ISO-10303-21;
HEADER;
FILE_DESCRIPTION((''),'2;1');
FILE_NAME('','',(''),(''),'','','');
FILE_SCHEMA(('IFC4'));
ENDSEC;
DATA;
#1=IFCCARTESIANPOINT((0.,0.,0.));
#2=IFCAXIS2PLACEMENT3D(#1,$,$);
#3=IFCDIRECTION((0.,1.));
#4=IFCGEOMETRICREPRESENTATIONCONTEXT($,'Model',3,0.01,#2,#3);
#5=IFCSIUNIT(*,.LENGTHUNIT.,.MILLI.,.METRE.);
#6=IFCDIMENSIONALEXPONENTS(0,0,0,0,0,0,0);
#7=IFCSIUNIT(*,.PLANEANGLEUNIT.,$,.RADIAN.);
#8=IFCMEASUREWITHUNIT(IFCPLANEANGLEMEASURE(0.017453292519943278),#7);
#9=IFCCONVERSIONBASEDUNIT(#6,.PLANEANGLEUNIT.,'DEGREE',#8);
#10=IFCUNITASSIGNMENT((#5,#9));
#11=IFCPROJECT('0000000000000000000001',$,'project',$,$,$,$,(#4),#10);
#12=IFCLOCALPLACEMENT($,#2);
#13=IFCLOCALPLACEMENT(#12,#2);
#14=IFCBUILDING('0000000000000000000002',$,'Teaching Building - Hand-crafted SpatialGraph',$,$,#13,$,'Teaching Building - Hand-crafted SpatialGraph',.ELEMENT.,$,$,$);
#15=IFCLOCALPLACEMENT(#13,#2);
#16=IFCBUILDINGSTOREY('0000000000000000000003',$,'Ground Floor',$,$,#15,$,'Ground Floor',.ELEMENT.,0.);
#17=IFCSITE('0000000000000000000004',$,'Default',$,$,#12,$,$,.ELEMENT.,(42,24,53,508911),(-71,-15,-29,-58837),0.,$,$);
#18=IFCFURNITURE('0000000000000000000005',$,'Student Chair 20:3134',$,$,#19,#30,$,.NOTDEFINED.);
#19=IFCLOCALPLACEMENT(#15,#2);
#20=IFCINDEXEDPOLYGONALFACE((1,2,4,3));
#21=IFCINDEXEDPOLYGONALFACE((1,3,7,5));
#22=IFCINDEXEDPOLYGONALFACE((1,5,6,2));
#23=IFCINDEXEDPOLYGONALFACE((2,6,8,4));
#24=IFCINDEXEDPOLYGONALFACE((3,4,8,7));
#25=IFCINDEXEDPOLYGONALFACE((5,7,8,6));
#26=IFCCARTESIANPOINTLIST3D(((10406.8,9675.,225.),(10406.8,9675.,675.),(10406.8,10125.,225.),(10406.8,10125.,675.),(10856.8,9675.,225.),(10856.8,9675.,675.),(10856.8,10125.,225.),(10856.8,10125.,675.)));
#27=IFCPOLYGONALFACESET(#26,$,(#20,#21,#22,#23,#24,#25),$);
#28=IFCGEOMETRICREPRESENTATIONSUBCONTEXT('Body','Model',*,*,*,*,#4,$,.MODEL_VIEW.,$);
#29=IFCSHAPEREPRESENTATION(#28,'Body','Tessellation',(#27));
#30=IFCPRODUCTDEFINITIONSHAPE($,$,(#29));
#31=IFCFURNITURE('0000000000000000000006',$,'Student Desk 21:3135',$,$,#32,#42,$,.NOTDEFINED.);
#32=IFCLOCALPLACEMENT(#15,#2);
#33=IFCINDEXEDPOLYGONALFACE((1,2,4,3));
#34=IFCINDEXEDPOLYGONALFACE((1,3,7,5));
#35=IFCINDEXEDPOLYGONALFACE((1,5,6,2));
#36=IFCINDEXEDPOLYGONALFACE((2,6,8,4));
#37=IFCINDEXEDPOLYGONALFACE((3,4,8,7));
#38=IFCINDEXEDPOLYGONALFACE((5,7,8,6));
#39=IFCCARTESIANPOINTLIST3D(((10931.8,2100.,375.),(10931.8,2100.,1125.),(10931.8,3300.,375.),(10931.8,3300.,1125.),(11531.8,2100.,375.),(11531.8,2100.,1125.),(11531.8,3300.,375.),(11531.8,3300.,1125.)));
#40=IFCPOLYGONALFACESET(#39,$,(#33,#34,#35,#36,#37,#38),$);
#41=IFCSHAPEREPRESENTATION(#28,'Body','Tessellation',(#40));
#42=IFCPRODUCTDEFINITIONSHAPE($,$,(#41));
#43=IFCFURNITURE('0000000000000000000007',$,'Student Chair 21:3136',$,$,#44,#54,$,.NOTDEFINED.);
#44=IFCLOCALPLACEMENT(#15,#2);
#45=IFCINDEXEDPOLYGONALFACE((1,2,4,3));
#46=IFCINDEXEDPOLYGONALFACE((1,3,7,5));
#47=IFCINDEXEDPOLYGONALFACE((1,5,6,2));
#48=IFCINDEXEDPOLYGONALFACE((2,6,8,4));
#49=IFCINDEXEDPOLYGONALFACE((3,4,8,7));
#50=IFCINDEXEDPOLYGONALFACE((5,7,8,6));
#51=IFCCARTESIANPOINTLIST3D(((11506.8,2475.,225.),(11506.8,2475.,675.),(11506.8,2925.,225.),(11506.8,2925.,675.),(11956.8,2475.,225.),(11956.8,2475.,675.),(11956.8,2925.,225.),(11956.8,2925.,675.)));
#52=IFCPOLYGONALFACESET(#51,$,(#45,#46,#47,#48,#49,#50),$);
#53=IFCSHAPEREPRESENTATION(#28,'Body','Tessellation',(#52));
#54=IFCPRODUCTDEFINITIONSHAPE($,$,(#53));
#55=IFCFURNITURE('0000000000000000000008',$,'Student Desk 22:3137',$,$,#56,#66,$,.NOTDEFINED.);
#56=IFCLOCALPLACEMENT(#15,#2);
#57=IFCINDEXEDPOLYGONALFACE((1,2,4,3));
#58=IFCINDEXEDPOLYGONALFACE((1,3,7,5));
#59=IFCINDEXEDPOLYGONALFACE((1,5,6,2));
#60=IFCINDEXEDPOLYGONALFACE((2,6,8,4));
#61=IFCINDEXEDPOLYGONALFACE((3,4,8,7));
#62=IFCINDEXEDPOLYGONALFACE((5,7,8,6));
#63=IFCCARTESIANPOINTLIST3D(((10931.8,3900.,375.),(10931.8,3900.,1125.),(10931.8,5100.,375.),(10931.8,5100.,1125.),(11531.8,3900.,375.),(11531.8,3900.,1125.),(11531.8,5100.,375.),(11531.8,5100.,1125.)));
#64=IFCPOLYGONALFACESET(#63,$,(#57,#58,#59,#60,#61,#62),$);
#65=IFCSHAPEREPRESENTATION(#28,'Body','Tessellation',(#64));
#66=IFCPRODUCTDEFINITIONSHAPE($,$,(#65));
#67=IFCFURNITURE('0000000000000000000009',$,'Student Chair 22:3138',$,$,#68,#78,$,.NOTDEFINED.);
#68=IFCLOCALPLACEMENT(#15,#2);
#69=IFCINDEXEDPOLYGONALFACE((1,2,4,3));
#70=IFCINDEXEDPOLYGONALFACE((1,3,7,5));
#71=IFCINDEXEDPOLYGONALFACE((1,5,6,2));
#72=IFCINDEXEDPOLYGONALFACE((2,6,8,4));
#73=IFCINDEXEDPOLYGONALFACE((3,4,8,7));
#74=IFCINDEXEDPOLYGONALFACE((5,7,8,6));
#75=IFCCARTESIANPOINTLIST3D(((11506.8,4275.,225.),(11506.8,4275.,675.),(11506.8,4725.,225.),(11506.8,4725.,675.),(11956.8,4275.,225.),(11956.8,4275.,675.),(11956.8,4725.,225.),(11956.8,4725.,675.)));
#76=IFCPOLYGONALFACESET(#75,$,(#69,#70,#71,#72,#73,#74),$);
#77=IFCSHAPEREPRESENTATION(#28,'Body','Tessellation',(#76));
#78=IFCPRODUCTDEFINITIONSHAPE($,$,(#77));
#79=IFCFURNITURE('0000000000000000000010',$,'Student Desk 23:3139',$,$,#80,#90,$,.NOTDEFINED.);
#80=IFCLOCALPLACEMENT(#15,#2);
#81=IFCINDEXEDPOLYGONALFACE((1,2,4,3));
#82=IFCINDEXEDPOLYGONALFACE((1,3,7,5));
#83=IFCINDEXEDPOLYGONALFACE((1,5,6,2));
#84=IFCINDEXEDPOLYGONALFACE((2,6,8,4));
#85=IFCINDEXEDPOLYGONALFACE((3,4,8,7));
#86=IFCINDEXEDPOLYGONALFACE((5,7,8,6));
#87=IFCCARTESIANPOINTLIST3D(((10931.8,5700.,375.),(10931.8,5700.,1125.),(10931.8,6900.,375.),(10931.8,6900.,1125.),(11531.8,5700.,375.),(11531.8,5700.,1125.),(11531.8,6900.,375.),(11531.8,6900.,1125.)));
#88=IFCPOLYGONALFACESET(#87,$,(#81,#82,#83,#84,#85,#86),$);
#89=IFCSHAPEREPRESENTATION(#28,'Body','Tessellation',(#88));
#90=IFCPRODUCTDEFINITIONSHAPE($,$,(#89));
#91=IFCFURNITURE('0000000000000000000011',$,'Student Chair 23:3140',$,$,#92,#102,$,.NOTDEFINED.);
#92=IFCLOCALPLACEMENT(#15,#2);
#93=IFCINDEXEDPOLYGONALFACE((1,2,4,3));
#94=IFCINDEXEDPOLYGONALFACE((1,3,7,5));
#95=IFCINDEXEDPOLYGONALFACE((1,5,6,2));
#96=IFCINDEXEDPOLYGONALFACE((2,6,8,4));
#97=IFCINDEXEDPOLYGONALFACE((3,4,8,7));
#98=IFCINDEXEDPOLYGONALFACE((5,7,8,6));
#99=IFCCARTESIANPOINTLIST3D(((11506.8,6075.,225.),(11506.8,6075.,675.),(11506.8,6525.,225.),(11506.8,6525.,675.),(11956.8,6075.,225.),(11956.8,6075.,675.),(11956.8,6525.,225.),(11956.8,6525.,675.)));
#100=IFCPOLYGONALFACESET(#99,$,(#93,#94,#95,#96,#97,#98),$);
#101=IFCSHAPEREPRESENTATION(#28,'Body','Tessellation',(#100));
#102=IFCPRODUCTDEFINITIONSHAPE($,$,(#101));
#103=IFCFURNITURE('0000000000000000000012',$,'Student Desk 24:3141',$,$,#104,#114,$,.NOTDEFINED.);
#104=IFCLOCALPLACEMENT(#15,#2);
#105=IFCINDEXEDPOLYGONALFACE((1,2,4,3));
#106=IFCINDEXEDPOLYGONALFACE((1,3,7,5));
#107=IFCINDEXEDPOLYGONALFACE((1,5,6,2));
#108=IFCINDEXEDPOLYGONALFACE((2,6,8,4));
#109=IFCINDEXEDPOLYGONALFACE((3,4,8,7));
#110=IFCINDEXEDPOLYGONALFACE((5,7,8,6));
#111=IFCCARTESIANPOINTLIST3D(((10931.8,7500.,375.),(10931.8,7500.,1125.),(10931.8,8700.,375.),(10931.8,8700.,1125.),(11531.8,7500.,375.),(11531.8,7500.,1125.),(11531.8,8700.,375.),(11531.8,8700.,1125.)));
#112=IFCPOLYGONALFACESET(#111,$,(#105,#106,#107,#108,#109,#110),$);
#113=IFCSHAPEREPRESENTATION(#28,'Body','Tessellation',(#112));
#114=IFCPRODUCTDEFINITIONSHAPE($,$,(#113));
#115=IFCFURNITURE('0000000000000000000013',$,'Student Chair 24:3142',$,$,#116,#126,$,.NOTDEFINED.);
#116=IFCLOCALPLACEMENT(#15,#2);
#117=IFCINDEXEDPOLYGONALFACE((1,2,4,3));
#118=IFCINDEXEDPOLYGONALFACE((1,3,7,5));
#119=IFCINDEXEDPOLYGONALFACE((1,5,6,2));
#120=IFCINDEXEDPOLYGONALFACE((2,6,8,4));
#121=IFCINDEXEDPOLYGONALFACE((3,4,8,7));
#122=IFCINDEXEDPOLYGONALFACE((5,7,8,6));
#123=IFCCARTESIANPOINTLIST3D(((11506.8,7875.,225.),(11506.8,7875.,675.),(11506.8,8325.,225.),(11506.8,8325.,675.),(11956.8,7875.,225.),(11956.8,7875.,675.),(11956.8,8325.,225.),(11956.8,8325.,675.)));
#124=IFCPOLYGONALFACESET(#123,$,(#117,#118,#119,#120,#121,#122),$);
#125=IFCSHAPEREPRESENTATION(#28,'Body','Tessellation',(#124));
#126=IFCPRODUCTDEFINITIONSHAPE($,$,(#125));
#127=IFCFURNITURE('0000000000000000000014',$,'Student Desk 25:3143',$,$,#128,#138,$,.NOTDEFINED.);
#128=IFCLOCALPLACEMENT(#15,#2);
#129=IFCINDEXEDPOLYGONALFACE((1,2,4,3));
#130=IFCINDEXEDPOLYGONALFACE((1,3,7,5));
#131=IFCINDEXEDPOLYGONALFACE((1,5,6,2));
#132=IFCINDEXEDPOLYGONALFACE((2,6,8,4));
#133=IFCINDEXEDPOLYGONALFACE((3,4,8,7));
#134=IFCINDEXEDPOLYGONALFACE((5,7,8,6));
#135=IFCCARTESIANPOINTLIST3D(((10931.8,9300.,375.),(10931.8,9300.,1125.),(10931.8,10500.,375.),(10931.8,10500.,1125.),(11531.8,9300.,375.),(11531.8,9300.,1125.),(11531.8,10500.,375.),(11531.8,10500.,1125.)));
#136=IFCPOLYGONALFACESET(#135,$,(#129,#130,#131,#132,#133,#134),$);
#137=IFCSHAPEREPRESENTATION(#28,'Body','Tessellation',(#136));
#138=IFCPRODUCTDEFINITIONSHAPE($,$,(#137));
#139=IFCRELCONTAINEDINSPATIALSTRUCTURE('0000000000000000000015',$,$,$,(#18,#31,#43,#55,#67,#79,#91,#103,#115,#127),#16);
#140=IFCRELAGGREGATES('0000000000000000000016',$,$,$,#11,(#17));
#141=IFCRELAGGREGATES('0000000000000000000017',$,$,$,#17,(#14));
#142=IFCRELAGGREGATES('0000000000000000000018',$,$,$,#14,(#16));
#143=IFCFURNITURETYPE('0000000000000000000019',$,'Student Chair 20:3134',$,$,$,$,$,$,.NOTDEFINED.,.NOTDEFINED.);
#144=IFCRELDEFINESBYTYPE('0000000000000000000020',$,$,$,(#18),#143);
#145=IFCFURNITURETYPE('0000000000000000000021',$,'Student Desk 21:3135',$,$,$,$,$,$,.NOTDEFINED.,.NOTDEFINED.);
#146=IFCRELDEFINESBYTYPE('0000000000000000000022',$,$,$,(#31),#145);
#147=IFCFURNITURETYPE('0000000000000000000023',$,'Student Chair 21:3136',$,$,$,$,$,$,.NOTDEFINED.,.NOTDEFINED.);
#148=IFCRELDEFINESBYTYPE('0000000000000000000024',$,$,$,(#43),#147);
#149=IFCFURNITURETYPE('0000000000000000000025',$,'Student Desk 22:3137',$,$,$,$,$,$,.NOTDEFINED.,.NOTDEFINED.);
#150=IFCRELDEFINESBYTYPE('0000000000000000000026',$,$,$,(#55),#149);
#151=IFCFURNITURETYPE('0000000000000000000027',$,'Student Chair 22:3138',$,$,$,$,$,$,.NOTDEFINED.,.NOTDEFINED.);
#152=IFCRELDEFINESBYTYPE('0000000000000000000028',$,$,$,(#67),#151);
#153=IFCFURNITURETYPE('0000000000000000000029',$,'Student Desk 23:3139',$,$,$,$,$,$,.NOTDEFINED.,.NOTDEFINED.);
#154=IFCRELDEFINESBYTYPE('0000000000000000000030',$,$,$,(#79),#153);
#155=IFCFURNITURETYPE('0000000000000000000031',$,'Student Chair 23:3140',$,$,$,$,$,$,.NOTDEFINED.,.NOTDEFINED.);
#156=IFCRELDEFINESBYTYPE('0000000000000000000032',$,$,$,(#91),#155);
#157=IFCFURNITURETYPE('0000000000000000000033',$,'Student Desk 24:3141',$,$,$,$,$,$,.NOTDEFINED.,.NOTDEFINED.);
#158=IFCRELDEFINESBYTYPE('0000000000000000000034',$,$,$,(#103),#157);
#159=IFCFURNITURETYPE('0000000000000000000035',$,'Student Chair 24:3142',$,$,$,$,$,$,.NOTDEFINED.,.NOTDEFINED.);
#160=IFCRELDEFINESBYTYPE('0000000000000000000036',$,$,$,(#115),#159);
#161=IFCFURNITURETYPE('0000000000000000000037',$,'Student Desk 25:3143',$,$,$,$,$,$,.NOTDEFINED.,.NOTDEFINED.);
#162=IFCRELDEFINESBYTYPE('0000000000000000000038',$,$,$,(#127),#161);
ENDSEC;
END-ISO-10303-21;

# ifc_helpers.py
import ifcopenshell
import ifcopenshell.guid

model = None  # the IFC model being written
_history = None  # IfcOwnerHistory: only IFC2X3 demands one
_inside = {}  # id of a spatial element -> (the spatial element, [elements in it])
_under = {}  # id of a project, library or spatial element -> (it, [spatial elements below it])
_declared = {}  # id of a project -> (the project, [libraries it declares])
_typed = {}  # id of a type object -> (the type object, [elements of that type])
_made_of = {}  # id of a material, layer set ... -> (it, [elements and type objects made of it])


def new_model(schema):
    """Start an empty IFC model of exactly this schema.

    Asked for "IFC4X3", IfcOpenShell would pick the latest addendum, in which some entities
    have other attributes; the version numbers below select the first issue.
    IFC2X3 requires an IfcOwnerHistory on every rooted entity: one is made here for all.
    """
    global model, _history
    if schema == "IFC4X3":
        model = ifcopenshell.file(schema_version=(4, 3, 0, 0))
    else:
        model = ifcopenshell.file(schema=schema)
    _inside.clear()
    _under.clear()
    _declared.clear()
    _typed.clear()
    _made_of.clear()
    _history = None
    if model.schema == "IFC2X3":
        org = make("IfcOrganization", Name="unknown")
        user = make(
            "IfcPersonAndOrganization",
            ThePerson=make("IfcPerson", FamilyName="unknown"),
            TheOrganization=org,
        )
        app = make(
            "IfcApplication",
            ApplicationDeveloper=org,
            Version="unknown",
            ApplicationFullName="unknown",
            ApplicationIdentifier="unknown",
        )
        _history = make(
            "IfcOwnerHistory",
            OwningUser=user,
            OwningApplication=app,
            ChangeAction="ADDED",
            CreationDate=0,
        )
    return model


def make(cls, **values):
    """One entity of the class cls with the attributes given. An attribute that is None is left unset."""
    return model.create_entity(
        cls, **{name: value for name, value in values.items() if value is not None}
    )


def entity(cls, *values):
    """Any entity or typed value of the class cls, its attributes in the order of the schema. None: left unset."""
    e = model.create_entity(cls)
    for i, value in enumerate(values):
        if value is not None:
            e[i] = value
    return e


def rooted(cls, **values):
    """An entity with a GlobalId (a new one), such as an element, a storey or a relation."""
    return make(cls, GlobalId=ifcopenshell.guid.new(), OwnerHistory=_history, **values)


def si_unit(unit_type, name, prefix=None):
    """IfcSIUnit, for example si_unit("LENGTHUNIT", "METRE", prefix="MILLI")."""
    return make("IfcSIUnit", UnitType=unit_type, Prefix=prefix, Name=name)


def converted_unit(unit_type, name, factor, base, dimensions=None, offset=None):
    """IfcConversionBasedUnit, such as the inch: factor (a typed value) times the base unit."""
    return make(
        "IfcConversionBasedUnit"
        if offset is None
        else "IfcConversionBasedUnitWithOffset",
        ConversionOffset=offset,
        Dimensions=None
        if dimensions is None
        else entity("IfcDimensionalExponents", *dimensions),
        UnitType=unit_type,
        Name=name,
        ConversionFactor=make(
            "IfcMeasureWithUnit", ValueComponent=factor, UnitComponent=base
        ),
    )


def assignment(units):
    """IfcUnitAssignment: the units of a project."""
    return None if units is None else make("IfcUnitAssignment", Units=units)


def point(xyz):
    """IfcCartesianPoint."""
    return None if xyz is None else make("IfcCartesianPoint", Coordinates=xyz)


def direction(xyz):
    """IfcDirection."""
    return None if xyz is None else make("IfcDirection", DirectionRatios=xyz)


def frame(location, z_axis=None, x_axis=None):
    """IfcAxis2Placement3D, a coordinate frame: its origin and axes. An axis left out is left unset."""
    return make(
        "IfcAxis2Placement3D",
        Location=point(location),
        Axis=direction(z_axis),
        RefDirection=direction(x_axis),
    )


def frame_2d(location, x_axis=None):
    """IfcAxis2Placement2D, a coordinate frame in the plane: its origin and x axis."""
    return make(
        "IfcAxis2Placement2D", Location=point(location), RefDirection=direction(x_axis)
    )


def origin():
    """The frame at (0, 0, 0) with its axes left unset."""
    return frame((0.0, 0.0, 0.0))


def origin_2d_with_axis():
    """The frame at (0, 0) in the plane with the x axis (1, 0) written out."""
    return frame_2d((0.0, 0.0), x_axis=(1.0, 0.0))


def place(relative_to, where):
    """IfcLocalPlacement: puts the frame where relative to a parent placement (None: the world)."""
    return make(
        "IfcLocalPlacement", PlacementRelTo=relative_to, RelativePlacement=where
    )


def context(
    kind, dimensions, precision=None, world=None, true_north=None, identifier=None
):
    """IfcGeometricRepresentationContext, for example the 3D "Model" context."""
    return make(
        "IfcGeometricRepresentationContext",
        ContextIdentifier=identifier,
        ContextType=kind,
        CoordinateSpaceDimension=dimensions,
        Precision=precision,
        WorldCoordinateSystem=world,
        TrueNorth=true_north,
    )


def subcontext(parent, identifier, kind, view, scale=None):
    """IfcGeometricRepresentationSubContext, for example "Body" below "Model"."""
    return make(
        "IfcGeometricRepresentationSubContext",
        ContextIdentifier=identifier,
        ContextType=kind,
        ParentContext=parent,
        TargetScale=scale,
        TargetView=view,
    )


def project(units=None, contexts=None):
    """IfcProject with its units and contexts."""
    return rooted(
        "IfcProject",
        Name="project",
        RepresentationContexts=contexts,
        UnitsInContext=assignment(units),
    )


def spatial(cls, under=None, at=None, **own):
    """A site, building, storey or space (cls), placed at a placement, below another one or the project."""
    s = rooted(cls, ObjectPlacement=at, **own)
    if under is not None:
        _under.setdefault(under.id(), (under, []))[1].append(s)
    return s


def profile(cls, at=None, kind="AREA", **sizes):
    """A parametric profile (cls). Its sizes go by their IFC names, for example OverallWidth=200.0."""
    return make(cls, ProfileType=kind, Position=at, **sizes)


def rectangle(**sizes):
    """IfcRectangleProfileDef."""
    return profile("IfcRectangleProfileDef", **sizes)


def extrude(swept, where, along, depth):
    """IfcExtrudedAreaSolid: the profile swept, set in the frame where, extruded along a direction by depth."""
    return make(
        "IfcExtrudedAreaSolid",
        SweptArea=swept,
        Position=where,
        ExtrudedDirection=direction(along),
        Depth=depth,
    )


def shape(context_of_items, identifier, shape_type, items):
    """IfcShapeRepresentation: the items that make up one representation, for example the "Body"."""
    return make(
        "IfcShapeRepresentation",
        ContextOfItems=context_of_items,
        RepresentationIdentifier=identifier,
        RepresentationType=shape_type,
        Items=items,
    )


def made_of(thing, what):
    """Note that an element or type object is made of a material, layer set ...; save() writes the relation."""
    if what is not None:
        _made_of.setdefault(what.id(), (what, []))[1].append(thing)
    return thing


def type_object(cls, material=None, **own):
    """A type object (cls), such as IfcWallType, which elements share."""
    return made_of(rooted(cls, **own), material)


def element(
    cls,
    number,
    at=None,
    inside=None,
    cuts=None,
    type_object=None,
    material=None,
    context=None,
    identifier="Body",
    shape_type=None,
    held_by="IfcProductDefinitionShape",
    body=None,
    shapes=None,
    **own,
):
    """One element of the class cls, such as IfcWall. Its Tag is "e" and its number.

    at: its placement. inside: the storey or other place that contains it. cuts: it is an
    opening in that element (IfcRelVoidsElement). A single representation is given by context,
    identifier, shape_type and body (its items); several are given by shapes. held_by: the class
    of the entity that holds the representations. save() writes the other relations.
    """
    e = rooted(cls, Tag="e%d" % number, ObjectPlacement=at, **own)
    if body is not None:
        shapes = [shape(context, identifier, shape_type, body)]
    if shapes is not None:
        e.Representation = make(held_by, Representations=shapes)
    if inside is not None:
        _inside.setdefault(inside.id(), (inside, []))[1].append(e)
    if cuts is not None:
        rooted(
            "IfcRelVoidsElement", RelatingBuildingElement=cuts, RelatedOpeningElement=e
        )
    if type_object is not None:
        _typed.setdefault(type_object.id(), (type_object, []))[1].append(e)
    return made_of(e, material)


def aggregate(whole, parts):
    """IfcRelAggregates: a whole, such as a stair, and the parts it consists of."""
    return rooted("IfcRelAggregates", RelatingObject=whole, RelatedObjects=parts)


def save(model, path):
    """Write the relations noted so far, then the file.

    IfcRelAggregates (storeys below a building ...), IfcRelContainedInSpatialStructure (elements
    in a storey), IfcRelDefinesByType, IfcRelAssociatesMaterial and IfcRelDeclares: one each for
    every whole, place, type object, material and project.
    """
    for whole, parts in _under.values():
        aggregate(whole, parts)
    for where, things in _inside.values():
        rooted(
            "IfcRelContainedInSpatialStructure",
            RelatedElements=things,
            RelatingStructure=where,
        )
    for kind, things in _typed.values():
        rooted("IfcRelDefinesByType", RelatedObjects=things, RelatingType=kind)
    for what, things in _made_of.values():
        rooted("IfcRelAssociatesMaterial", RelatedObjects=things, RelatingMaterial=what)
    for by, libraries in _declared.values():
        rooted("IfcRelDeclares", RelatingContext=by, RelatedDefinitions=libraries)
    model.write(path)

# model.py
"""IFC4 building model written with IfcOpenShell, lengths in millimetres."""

from ifc_helpers import new_model, entity, si_unit, converted_unit, direction, frame, frame_2d, origin, origin_2d_with_axis, place, context, subcontext, project, spatial, rectangle, extrude, type_object, element, save


model = new_model("IFC4")

# Units and contexts
model_context = context("Model", 3, precision=0.01, world=origin(), true_north=direction((0.0, 1.0)))
body_context = subcontext(model_context, "Body", "Model", "MODEL_VIEW")
ifc_project = project(units=[si_unit("LENGTHUNIT", "METRE", prefix="MILLI"), converted_unit("PLANEANGLEUNIT", "DEGREE", entity("IfcPlaneAngleMeasure", 0.017453292519943278), si_unit("PLANEANGLEUNIT", "RADIAN"), dimensions=[0, 0, 0, 0, 0, 0, 0])], contexts=[model_context])

# Site, building, storey
site_placement = place(None, origin())
site = spatial("IfcSite", under=ifc_project, at=site_placement, Name="Default", CompositionType="ELEMENT", RefLatitude=(42, 24, 53, 508911), RefLongitude=(-71, -15, -29, -58837), RefElevation=0.0)
building_placement = place(site_placement, origin())
building = spatial("IfcBuilding", under=site, at=building_placement, Name="Teaching Building - Hand-crafted SpatialGraph", LongName="Teaching Building - Hand-crafted SpatialGraph", CompositionType="ELEMENT")
storey_placement = place(building_placement, origin())
storey = spatial("IfcBuildingStorey", under=building, at=storey_placement, Name="Ground Floor", LongName="Ground Floor", CompositionType="ELEMENT", Elevation=0.0)

# Furniture
furniture_type_1 = type_object("IfcFurnitureType", Name="Student Chair 20:3134", PredefinedType="NOTDEFINED")
furniture_1_placement = place(storey_placement, origin())
element("IfcFurniture", 1, at=furniture_1_placement, inside=storey, type_object=furniture_type_1, Name="Student Chair 20:3134", PredefinedType="NOTDEFINED", context=body_context, shape_type="SweptSolid", body=[
    extrude(rectangle(XDim=450.0, YDim=450.0, at=frame_2d((0.0, 0.0), x_axis=(1.0, 0.0))), frame((10631.8, 9900.0, 225.0)), (0.0, 0.0, 1.0), 450.0),
])
furniture_type_2 = type_object("IfcFurnitureType", Name="Student Desk 21:3135", PredefinedType="NOTDEFINED")
furniture_2_placement = place(storey_placement, origin())
element("IfcFurniture", 2, at=furniture_2_placement, inside=storey, type_object=furniture_type_2, Name="Student Desk 21:3135", PredefinedType="NOTDEFINED", context=body_context, shape_type="SweptSolid", body=[
    extrude(rectangle(XDim=1200.0, YDim=600.0, at=origin_2d_with_axis()), frame((11231.8, 2700.0, 375.0), z_axis=(0.0, 0.0, 1.0), x_axis=(0.0, 1.0, 0.0)), (0.0, 0.0, 1.0), 750.0),
])
furniture_type_3 = type_object("IfcFurnitureType", Name="Student Chair 21:3136", PredefinedType="NOTDEFINED")
furniture_3_placement = place(storey_placement, origin())
element("IfcFurniture", 3, at=furniture_3_placement, inside=storey, type_object=furniture_type_3, Name="Student Chair 21:3136", PredefinedType="NOTDEFINED", context=body_context, shape_type="SweptSolid", body=[
    extrude(rectangle(XDim=450.0, YDim=450.0, at=origin_2d_with_axis()), frame((11731.8, 2700.0, 225.0)), (0.0, 0.0, 1.0), 450.0),
])
furniture_type_4 = type_object("IfcFurnitureType", Name="Student Desk 22:3137", PredefinedType="NOTDEFINED")
furniture_4_placement = place(storey_placement, origin())
element("IfcFurniture", 4, at=furniture_4_placement, inside=storey, type_object=furniture_type_4, Name="Student Desk 22:3137", PredefinedType="NOTDEFINED", context=body_context, shape_type="SweptSolid", body=[
    extrude(rectangle(XDim=1200.0, YDim=600.0, at=frame_2d((0.0, 0.0), x_axis=(1.0, 0.0))), frame((11231.8, 4500.0, 375.0), z_axis=(0.0, 0.0, 1.0), x_axis=(0.0, 1.0, 0.0)), (0.0, 0.0, 1.0), 750.0),
])
furniture_type_5 = type_object("IfcFurnitureType", Name="Student Chair 22:3138", PredefinedType="NOTDEFINED")
furniture_5_placement = place(storey_placement, origin())
element("IfcFurniture", 5, at=furniture_5_placement, inside=storey, type_object=furniture_type_5, Name="Student Chair 22:3138", PredefinedType="NOTDEFINED", context=body_context, shape_type="SweptSolid", body=[
    extrude(rectangle(XDim=450.0, YDim=450.0, at=origin_2d_with_axis()), frame((11731.8, 4500.0, 225.0)), (0.0, 0.0, 1.0), 450.0),
])
furniture_type_6 = type_object("IfcFurnitureType", Name="Student Desk 23:3139", PredefinedType="NOTDEFINED")
furniture_6_placement = place(storey_placement, origin())
element("IfcFurniture", 6, at=furniture_6_placement, inside=storey, type_object=furniture_type_6, Name="Student Desk 23:3139", PredefinedType="NOTDEFINED", context=body_context, shape_type="SweptSolid", body=[
    extrude(rectangle(XDim=1200.0, YDim=600.0, at=origin_2d_with_axis()), frame((11231.8, 6300.0, 375.0), z_axis=(0.0, 0.0, 1.0), x_axis=(0.0, 1.0, 0.0)), (0.0, 0.0, 1.0), 750.0),
])
furniture_type_7 = type_object("IfcFurnitureType", Name="Student Chair 23:3140", PredefinedType="NOTDEFINED")
furniture_7_placement = place(storey_placement, origin())
element("IfcFurniture", 7, at=furniture_7_placement, inside=storey, type_object=furniture_type_7, Name="Student Chair 23:3140", PredefinedType="NOTDEFINED", context=body_context, shape_type="SweptSolid", body=[
    extrude(rectangle(XDim=450.0, YDim=450.0, at=origin_2d_with_axis()), frame((11731.8, 6300.0, 225.0)), (0.0, 0.0, 1.0), 450.0),
])
furniture_type_8 = type_object("IfcFurnitureType", Name="Student Desk 24:3141", PredefinedType="NOTDEFINED")
furniture_8_placement = place(storey_placement, origin())
element("IfcFurniture", 8, at=furniture_8_placement, inside=storey, type_object=furniture_type_8, Name="Student Desk 24:3141", PredefinedType="NOTDEFINED", context=body_context, shape_type="SweptSolid", body=[
    extrude(rectangle(XDim=1200.0, YDim=600.0, at=origin_2d_with_axis()), frame((11231.8, 8100.0, 375.0), z_axis=(0.0, 0.0, 1.0), x_axis=(0.0, 1.0, 0.0)), (0.0, 0.0, 1.0), 750.0),
])
furniture_type_9 = type_object("IfcFurnitureType", Name="Student Chair 24:3142", PredefinedType="NOTDEFINED")
furniture_9_placement = place(storey_placement, origin())
element("IfcFurniture", 9, at=furniture_9_placement, inside=storey, type_object=furniture_type_9, Name="Student Chair 24:3142", PredefinedType="NOTDEFINED", context=body_context, shape_type="SweptSolid", body=[
    extrude(rectangle(XDim=450.0, YDim=450.0, at=origin_2d_with_axis()), frame((11731.8, 8100.0, 225.0)), (0.0, 0.0, 1.0), 450.0),
])
furniture_type_10 = type_object("IfcFurnitureType", Name="Student Desk 25:3143", PredefinedType="NOTDEFINED")
furniture_10_placement = place(storey_placement, origin())
element("IfcFurniture", 10, at=furniture_10_placement, inside=storey, type_object=furniture_type_10, Name="Student Desk 25:3143", PredefinedType="NOTDEFINED", context=body_context, shape_type="SweptSolid", body=[
    extrude(rectangle(XDim=1200.0, YDim=600.0, at=origin_2d_with_axis()), frame((11231.8, 9900.0, 375.0), z_axis=(0.0, 0.0, 1.0), x_axis=(0.0, 1.0, 0.0)), (0.0, 0.0, 1.0), 750.0),
])

save(model, "model.ifc")
